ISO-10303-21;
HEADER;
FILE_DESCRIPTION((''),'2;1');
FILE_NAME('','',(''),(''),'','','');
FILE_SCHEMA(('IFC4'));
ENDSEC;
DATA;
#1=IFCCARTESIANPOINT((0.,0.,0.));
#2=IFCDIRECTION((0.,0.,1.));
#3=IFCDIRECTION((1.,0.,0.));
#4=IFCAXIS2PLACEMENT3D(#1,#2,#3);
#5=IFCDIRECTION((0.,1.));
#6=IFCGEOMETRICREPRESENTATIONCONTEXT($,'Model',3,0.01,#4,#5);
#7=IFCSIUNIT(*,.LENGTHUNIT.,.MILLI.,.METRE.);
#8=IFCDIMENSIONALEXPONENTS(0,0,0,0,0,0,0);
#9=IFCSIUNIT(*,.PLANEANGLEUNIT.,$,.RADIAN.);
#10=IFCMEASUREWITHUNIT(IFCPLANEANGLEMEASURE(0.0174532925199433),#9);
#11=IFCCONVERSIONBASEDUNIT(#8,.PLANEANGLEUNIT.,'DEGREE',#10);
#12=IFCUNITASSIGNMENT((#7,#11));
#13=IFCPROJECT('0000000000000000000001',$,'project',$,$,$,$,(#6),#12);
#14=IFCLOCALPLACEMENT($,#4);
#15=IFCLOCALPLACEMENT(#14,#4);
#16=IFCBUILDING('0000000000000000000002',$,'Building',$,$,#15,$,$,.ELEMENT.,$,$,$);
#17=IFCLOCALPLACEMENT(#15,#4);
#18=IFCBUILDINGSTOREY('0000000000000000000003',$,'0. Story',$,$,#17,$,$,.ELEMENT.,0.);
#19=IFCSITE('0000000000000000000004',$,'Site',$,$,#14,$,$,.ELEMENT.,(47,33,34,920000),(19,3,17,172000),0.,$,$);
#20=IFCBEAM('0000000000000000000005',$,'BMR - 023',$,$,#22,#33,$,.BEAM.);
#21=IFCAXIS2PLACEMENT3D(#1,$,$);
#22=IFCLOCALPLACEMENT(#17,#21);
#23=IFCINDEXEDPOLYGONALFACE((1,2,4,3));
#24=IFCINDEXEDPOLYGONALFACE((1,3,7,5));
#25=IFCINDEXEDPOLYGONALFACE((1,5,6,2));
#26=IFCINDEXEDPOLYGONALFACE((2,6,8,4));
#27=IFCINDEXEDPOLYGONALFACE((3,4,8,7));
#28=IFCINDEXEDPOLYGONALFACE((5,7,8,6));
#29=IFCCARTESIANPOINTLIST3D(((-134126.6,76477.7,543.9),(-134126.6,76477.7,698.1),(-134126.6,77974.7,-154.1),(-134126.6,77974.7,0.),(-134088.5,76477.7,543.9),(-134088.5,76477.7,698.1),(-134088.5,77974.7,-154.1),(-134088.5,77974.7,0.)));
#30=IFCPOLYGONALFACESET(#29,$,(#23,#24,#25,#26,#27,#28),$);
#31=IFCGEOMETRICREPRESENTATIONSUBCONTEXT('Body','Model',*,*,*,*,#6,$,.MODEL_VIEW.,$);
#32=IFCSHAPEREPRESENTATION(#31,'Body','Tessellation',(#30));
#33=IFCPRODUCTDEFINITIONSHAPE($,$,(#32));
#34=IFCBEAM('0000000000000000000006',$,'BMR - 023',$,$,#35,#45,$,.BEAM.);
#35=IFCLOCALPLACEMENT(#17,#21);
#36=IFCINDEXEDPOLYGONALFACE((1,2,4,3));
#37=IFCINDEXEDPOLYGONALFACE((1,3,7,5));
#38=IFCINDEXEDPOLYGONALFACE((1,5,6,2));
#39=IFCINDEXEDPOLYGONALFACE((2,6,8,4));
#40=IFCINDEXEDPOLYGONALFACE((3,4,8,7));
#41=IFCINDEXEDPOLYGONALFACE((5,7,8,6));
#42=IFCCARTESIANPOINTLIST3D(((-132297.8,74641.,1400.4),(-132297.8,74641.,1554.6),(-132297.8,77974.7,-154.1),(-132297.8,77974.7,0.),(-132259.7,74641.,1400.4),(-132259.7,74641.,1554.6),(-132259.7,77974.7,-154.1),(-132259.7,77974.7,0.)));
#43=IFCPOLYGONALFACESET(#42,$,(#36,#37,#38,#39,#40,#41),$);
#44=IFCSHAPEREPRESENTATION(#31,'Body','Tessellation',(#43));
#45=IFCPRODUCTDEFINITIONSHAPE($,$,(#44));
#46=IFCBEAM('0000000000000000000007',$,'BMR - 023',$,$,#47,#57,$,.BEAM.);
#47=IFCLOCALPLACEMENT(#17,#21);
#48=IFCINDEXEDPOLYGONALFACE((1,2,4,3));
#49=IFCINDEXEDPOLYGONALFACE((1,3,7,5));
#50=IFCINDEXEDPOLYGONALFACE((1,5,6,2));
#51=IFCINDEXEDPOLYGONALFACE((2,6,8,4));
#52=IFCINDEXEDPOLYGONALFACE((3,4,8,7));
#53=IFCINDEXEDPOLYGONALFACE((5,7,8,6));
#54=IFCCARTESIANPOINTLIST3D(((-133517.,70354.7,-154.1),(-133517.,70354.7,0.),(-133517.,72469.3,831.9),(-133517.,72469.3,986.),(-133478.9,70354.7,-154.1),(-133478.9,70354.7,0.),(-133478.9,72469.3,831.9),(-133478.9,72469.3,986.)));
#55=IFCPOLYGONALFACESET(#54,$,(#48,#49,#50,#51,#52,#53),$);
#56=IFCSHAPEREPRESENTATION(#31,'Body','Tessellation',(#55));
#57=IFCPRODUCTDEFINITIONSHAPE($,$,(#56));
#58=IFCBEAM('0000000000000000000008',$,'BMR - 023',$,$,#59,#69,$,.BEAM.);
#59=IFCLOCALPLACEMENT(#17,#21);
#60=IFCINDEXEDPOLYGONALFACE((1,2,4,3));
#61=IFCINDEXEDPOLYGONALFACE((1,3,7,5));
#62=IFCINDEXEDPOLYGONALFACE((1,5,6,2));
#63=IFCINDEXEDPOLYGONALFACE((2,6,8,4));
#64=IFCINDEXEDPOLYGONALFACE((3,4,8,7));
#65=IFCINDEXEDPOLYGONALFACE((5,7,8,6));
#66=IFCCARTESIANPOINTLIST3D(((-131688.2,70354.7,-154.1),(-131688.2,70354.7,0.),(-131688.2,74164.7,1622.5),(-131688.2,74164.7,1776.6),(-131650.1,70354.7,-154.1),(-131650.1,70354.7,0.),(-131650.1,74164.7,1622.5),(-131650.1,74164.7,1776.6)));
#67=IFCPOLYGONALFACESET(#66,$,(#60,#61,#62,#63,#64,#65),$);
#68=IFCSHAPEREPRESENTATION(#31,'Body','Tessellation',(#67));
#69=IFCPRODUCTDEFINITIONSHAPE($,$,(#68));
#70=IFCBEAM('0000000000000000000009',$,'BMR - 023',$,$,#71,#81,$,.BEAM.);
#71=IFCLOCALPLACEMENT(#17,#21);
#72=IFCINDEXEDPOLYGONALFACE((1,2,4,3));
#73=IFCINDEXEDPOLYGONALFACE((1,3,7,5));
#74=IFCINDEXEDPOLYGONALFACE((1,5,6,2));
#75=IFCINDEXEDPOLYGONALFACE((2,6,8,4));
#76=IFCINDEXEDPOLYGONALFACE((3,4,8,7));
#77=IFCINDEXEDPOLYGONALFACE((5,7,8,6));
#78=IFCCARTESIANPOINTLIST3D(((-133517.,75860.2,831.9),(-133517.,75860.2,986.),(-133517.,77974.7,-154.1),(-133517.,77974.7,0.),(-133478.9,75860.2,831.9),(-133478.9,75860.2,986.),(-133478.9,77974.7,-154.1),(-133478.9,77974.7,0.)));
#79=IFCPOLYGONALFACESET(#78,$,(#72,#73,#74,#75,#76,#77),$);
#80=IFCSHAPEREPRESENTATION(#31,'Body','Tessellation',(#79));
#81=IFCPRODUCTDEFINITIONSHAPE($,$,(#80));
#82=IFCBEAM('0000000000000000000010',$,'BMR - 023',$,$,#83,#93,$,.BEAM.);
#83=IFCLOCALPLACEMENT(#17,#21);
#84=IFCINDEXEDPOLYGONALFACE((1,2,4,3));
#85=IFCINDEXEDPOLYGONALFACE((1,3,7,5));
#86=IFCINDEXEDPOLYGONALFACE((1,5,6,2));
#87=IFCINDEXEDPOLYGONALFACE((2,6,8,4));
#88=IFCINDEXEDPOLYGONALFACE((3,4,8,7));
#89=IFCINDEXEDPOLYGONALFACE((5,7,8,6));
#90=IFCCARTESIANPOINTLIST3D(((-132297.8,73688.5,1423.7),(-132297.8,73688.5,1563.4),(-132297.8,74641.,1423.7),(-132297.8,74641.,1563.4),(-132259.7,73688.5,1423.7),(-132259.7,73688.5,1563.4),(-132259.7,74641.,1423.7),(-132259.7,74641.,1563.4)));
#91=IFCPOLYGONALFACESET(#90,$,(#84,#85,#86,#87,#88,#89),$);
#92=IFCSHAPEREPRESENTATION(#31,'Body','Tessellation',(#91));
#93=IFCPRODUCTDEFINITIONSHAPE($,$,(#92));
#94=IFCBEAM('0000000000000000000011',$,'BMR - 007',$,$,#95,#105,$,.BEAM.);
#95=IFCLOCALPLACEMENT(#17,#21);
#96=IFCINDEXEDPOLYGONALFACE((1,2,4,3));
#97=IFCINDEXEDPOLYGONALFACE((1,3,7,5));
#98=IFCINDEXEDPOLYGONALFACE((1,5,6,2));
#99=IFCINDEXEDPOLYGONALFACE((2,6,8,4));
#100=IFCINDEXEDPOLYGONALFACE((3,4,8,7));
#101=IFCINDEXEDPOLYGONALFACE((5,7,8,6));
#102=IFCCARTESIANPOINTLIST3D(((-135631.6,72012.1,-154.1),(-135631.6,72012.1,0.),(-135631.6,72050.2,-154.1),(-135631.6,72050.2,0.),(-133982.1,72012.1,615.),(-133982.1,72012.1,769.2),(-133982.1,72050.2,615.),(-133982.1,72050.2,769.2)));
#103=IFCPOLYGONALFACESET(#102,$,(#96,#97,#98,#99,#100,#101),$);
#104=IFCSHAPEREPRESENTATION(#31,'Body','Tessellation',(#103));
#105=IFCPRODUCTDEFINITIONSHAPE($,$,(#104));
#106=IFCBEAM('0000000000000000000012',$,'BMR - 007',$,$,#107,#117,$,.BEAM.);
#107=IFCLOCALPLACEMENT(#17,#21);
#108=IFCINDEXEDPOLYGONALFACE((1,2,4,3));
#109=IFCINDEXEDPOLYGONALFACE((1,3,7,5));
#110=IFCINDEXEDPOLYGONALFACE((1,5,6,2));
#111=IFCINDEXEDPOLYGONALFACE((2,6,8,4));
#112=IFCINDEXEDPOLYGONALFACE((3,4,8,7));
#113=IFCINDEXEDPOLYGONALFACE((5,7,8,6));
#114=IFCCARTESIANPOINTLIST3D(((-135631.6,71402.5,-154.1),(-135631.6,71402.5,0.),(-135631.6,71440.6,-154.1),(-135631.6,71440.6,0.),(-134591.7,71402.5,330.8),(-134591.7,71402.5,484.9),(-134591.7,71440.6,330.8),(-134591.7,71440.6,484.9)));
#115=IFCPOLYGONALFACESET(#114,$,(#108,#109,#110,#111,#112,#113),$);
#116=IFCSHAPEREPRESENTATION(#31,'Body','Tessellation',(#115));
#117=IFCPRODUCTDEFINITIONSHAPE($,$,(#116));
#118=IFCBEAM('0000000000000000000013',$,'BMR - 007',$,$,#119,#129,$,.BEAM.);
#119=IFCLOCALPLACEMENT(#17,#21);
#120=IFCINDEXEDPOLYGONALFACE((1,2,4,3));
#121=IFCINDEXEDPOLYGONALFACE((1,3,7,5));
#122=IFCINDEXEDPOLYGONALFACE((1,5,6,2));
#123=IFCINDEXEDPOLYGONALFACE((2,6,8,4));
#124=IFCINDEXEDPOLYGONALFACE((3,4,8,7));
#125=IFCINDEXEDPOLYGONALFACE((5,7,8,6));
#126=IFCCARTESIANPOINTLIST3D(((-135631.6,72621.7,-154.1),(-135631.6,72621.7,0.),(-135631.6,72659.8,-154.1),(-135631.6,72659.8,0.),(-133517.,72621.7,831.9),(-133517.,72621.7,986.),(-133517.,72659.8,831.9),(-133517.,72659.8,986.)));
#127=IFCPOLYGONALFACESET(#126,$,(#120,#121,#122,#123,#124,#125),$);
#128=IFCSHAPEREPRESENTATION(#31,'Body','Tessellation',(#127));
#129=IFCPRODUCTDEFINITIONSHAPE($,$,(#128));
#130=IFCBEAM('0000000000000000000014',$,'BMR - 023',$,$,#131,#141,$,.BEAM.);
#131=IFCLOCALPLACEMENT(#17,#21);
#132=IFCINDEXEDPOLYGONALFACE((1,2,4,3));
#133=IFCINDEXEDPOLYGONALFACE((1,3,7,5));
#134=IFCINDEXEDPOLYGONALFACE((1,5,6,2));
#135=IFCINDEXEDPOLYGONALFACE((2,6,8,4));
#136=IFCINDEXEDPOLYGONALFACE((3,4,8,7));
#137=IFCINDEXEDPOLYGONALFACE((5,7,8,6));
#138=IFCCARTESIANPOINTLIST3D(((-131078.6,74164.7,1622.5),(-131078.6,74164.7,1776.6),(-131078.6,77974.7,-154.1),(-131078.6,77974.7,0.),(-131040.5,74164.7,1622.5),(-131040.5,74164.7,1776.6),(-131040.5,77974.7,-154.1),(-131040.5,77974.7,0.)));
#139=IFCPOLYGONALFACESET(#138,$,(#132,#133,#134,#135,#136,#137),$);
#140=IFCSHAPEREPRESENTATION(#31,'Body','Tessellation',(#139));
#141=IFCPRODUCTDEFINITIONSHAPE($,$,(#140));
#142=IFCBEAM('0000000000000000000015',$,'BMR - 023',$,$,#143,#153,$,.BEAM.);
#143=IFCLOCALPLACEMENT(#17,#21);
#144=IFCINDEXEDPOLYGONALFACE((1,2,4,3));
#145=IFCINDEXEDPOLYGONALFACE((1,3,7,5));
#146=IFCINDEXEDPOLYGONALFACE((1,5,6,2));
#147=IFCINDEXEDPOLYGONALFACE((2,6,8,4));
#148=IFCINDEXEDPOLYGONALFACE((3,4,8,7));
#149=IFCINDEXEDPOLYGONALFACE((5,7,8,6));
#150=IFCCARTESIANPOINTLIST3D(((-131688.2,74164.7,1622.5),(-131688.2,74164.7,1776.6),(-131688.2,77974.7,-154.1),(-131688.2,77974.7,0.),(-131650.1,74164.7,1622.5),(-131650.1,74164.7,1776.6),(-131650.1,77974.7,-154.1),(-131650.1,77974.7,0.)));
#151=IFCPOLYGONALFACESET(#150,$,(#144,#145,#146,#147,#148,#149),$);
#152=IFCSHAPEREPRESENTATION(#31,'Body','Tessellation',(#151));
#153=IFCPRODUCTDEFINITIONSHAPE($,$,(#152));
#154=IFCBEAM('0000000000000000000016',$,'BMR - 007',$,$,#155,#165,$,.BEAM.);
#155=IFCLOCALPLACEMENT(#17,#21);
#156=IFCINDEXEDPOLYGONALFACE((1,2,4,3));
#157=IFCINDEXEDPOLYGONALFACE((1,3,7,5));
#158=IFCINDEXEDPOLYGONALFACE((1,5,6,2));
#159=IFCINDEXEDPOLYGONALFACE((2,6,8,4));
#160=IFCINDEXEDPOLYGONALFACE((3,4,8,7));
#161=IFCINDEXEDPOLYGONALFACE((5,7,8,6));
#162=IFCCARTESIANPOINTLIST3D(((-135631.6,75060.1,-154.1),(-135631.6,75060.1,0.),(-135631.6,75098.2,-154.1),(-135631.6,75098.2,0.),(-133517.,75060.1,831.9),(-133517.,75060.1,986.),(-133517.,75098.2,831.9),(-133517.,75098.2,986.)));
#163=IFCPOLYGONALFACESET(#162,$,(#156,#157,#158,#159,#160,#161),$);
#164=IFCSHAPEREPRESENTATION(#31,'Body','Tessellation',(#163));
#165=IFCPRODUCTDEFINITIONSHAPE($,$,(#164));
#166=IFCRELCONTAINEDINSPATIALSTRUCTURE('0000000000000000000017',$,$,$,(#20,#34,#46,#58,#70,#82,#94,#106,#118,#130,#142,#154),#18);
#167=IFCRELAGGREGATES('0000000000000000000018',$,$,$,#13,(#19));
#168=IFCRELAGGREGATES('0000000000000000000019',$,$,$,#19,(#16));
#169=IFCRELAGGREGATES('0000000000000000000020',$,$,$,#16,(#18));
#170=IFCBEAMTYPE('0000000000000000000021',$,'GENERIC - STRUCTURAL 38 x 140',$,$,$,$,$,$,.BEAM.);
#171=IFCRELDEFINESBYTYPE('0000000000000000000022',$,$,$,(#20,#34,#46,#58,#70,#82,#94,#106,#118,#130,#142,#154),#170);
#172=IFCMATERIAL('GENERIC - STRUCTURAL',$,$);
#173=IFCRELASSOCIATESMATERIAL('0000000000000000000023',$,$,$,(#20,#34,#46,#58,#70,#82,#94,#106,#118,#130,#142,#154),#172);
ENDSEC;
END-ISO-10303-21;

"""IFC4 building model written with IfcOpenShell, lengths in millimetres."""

from ifc_helpers import new_model, entity, si_unit, converted_unit, direction, frame, frame_2d, origin_with_axes, place, context, subcontext, project, spatial, rectangle, extrude, clip, halfspace, material, type_object, element, save


model = new_model("IFC4")

# Units and contexts
model_context = context("Model", 3, precision=0.01, world=origin_with_axes(), true_north=direction((0.0, 1.0)))
body_context = subcontext(model_context, "Body", "Model", "MODEL_VIEW")
ifc_project = project(units=[si_unit("LENGTHUNIT", "METRE", prefix="MILLI"), converted_unit("PLANEANGLEUNIT", "DEGREE", entity("IfcPlaneAngleMeasure", 0.0174532925199433), si_unit("PLANEANGLEUNIT", "RADIAN"), dimensions=[0, 0, 0, 0, 0, 0, 0])], contexts=[model_context])

# Site, building, storey
site_placement = place(None, origin_with_axes())
site = spatial("IfcSite", under=ifc_project, at=site_placement, Name="Site", CompositionType="ELEMENT", RefLatitude=(47, 33, 34, 920000), RefLongitude=(19, 3, 17, 172000), RefElevation=0.0)
building_placement = place(site_placement, origin_with_axes())
building = spatial("IfcBuilding", under=site, at=building_placement, Name="Building", CompositionType="ELEMENT")
storey_placement = place(building_placement, origin_with_axes())
storey = spatial("IfcBuildingStorey", under=building, at=storey_placement, Name="0. Story", CompositionType="ELEMENT", Elevation=0.0)

# Beams
ifc_material = material(Name="GENERIC - STRUCTURAL")
beam_type = type_object("IfcBeamType", Name="GENERIC - STRUCTURAL 38 x 140", PredefinedType="BEAM")
beam_1_placement = place(storey_placement, frame((-134107.6, 77974.7, 0.0), z_axis=(0.0, 0.0, 1.0), x_axis=(-1.0, 0.0, 0.0)))
element("IfcBeam", 1, at=beam_1_placement, inside=storey, type_object=beam_type, material=ifc_material, Name="BMR - 023", PredefinedType="BEAM", context=body_context, shape_type="Clipping", body=[
    clip(clip(extrude(rectangle(XDim=139.7, YDim=38.1, at=frame_2d((-69.8, 0.0), x_axis=(1.0, 0.0))), frame((0.0, -83.5, -38.9), z_axis=(0.0, 0.906308, 0.422618), x_axis=(0.0, -0.422618, 0.906308)), (0.0, 0.0, 1.0), 1836.1), halfspace(frame((0.0, 0.0, 0.0), z_axis=(0.0, 1.0, 0.0), x_axis=(0.0, 0.0, 1.0)), True)), halfspace(frame((0.0, 1497.1, 0.0), z_axis=(0.0, -1.0, 0.0), x_axis=(0.0, 0.0, -1.0)), True)),
])
beam_2_placement = place(storey_placement, frame((-132278.8, 77974.7, 0.0), z_axis=(0.0, 0.0, 1.0), x_axis=(-1.0, 0.0, 0.0)))
element("IfcBeam", 2, at=beam_2_placement, inside=storey, type_object=beam_type, material=ifc_material, Name="BMR - 023", PredefinedType="BEAM", context=body_context, shape_type="Clipping", body=[
    clip(clip(extrude(rectangle(XDim=139.7, YDim=38.1, at=frame_2d((-69.8, 0.0), x_axis=(1.0, 0.0))), frame((0.0, -83.5, -38.9), z_axis=(0.0, 0.906308, 0.422618), x_axis=(0.0, -0.422618, 0.906308)), (0.0, 0.0, 1.0), 3862.6), halfspace(frame((0.0, 0.0, 0.0), z_axis=(0.0, 1.0, 0.0), x_axis=(0.0, 0.0, 1.0)), True)), halfspace(frame((0.0, 3333.8, 0.0), z_axis=(0.0, -1.0, 0.0), x_axis=(0.0, 0.0, -1.0)), True)),
])
beam_3_placement = place(storey_placement, frame((-133498.0, 70354.7, 0.0), z_axis=(0.0, 0.0, 1.0), x_axis=(1.0, 0.0, 0.0)))
element("IfcBeam", 3, at=beam_3_placement, inside=storey, type_object=beam_type, material=ifc_material, Name="BMR - 023", PredefinedType="BEAM", context=body_context, shape_type="Clipping", body=[
    clip(clip(extrude(rectangle(XDim=139.7, YDim=38.1, at=frame_2d((-69.8, 0.0), x_axis=(1.0, 0.0))), frame((0.0, -83.5, -38.9), z_axis=(0.0, 0.906308, 0.422618), x_axis=(0.0, -0.422618, 0.906308)), (0.0, 0.0, 1.0), 2517.4), halfspace(frame((0.0, 0.0, 0.0), z_axis=(0.0, 1.0, 0.0), x_axis=(0.0, 0.0, 1.0)), True)), halfspace(frame((0.0, 2114.5, 0.0), z_axis=(0.0, -1.0, 0.0), x_axis=(0.0, 0.0, -1.0)), True)),
])
beam_4_placement = place(storey_placement, frame((-131669.2, 70354.7, 0.0), z_axis=(0.0, 0.0, 1.0), x_axis=(1.0, 0.0, 0.0)))
element("IfcBeam", 4, at=beam_4_placement, inside=storey, type_object=beam_type, material=ifc_material, Name="BMR - 023", PredefinedType="BEAM", context=body_context, shape_type="Clipping", body=[
    clip(clip(extrude(rectangle(XDim=139.7, YDim=38.1, at=frame_2d((-69.8, 0.0), x_axis=(1.0, 0.0))), frame((0.0, -83.5, -38.9), z_axis=(0.0, 0.906308, 0.422618), x_axis=(0.0, -0.422618, 0.906308)), (0.0, 0.0, 1.0), 4388.1), halfspace(frame((0.0, 0.0, 0.0), z_axis=(0.0, 1.0, 0.0), x_axis=(0.0, 0.0, 1.0)), True)), halfspace(frame((0.0, 3810.0, 0.0), z_axis=(0.0, -1.0, 0.0), x_axis=(0.0, 0.0, -1.0)), True)),
])
beam_5_placement = place(storey_placement, frame((-133498.0, 77974.7, 0.0), z_axis=(0.0, 0.0, 1.0), x_axis=(-1.0, 0.0, 0.0)))
element("IfcBeam", 5, at=beam_5_placement, inside=storey, type_object=beam_type, material=ifc_material, Name="BMR - 023", PredefinedType="BEAM", context=body_context, shape_type="Clipping", body=[
    clip(clip(extrude(rectangle(XDim=139.7, YDim=38.1, at=frame_2d((-69.8, 0.0), x_axis=(1.0, 0.0))), frame((0.0, -83.5, -38.9), z_axis=(0.0, 0.906308, 0.422618), x_axis=(0.0, -0.422618, 0.906308)), (0.0, 0.0, 1.0), 2517.4), halfspace(frame((0.0, 0.0, 0.0), z_axis=(0.0, 1.0, 0.0), x_axis=(0.0, 0.0, 1.0)), True)), halfspace(frame((0.0, 2114.6, 0.0), z_axis=(0.0, -1.0, 0.0), x_axis=(0.0, 0.0, -1.0)), True)),
])
beam_6_placement = place(storey_placement, frame((-132278.8, 74641.0, 1563.4), z_axis=(0.0, 0.0, 1.0), x_axis=(-1.0, 0.0, 0.0)))
element("IfcBeam", 6, at=beam_6_placement, inside=storey, type_object=beam_type, material=ifc_material, Name="BMR - 023", PredefinedType="BEAM", context=body_context, shape_type="SweptSolid", body=[
    extrude(rectangle(XDim=139.7, YDim=38.1, at=frame_2d((-69.8, 0.0), x_axis=(1.0, 0.0))), frame((0.0, 0.0, 0.0), z_axis=(0.0, 1.0, 0.0), x_axis=(0.0, 0.0, 1.0)), (0.0, 0.0, 1.0), 952.5),
])
beam_7_placement = place(storey_placement, frame((-135631.6, 72031.1, 0.0), z_axis=(0.0, 0.0, 1.0), x_axis=(0.0, -1.0, 0.0)))
element("IfcBeam", 7, at=beam_7_placement, inside=storey, type_object=beam_type, material=ifc_material, Name="BMR - 007", PredefinedType="BEAM", context=body_context, shape_type="Clipping", body=[
    clip(clip(extrude(rectangle(XDim=139.7, YDim=38.1, at=frame_2d((-69.8, 0.0), x_axis=(1.0, 0.0))), frame((0.0, -83.5, -38.9), z_axis=(0.0, 0.906308, 0.422618), x_axis=(0.0, -0.422618, 0.906308)), (0.0, 0.0, 1.0), 2004.2), halfspace(frame((0.0, 0.0, 0.0), z_axis=(0.0, 1.0, 0.0), x_axis=(0.0, 0.0, 1.0)), True)), halfspace(frame((0.0, 1649.5, 0.0), z_axis=(0.0, -1.0, 0.0), x_axis=(0.0, 0.0, -1.0)), True)),
])
beam_8_placement = place(storey_placement, frame((-135631.6, 71421.5, 0.0), z_axis=(0.0, 0.0, 1.0), x_axis=(0.0, -1.0, 0.0)))
element("IfcBeam", 8, at=beam_8_placement, inside=storey, type_object=beam_type, material=ifc_material, Name="BMR - 007", PredefinedType="BEAM", context=body_context, shape_type="Clipping", body=[
    clip(clip(extrude(rectangle(XDim=139.7, YDim=38.1, at=frame_2d((-69.8, 0.0), x_axis=(1.0, 0.0))), frame((0.0, -83.5, -38.9), z_axis=(0.0, 0.906308, 0.422618), x_axis=(0.0, -0.422618, 0.906308)), (0.0, 0.0, 1.0), 1331.6), halfspace(frame((0.0, 0.0, 0.0), z_axis=(0.0, 1.0, 0.0), x_axis=(0.0, 0.0, 1.0)), True)), halfspace(frame((0.0, 1039.9, 0.0), z_axis=(0.0, -1.0, 0.0), x_axis=(0.0, 0.0, -1.0)), True)),
])
beam_9_placement = place(storey_placement, frame((-135631.6, 72640.7, 0.0), z_axis=(0.0, 0.0, 1.0), x_axis=(0.0, -1.0, 0.0)))
element("IfcBeam", 9, at=beam_9_placement, inside=storey, type_object=beam_type, material=ifc_material, Name="BMR - 007", PredefinedType="BEAM", context=body_context, shape_type="Clipping", body=[
    clip(clip(extrude(rectangle(XDim=139.7, YDim=38.1, at=frame_2d((-69.8, 0.0), x_axis=(1.0, 0.0))), frame((0.0, -83.5, -38.9), z_axis=(0.0, 0.906308, 0.422618), x_axis=(0.0, -0.422618, 0.906308)), (0.0, 0.0, 1.0), 2517.4), halfspace(frame((0.0, 0.0, 0.0), z_axis=(0.0, 1.0, 0.0), x_axis=(0.0, 0.0, 1.0)), True)), halfspace(frame((0.0, 2114.5, 0.0), z_axis=(0.0, -1.0, 0.0), x_axis=(0.0, 0.0, -1.0)), True)),
])
beam_10_placement = place(storey_placement, frame((-131059.6, 77974.7, 0.0), z_axis=(0.0, 0.0, 1.0), x_axis=(-1.0, 0.0, 0.0)))
element("IfcBeam", 10, at=beam_10_placement, inside=storey, type_object=beam_type, material=ifc_material, Name="BMR - 023", PredefinedType="BEAM", context=body_context, shape_type="Clipping", body=[
    clip(clip(extrude(rectangle(XDim=139.7, YDim=38.1, at=frame_2d((-69.8, 0.0), x_axis=(1.0, 0.0))), frame((0.0, -83.5, -38.9), z_axis=(0.0, 0.906308, 0.422618), x_axis=(0.0, -0.422618, 0.906308)), (0.0, 0.0, 1.0), 4388.1), halfspace(frame((0.0, 0.0, 0.0), z_axis=(0.0, 1.0, 0.0), x_axis=(0.0, 0.0, 1.0)), True)), halfspace(frame((0.0, 3810.0, 0.0), z_axis=(0.0, -1.0, 0.0), x_axis=(0.0, 0.0, -1.0)), True)),
])
beam_11_placement = place(storey_placement, frame((-131669.2, 77974.7, 0.0), z_axis=(0.0, 0.0, 1.0), x_axis=(-1.0, 0.0, 0.0)))
element("IfcBeam", 11, at=beam_11_placement, inside=storey, type_object=beam_type, material=ifc_material, Name="BMR - 023", PredefinedType="BEAM", context=body_context, shape_type="Clipping", body=[
    clip(clip(extrude(rectangle(XDim=139.7, YDim=38.1, at=frame_2d((-69.8, 0.0), x_axis=(1.0, 0.0))), frame((0.0, -83.5, -38.9), z_axis=(0.0, 0.906308, 0.422618), x_axis=(0.0, -0.422618, 0.906308)), (0.0, 0.0, 1.0), 4388.1), halfspace(frame((0.0, 0.0, 0.0), z_axis=(0.0, 1.0, 0.0), x_axis=(0.0, 0.0, 1.0)), True)), halfspace(frame((0.0, 3810.0, 0.0), z_axis=(0.0, -1.0, 0.0), x_axis=(0.0, 0.0, -1.0)), True)),
])
for number, where, z_axis, x_axis, name in (
    (12, (-135631.6, 75079.1, 0.0), (0.0, 0.0, 1.0), (0.0, -1.0, 0.0), "BMR - 007"),
):
    element("IfcBeam", number, at=place(storey_placement, frame(where, z_axis=z_axis, x_axis=x_axis)), inside=storey, type_object=beam_type, material=ifc_material, Name=name, PredefinedType="BEAM", context=body_context, shape_type="Clipping", body=[
        clip(clip(extrude(rectangle(XDim=139.7, YDim=38.1, at=frame_2d((-69.8, 0.0), x_axis=(1.0, 0.0))), frame((0.0, -83.5, -38.9), z_axis=(0.0, 0.906308, 0.422618), x_axis=(0.0, -0.422618, 0.906308)), (0.0, 0.0, 1.0), 2517.4), halfspace(frame((0.0, 0.0, 0.0), z_axis=(0.0, 1.0, 0.0), x_axis=(0.0, 0.0, 1.0)), True)), halfspace(frame((0.0, 2114.5, 0.0), z_axis=(0.0, -1.0, 0.0), x_axis=(0.0, 0.0, -1.0)), True)),
    ])

save(model, "model.ifc")
